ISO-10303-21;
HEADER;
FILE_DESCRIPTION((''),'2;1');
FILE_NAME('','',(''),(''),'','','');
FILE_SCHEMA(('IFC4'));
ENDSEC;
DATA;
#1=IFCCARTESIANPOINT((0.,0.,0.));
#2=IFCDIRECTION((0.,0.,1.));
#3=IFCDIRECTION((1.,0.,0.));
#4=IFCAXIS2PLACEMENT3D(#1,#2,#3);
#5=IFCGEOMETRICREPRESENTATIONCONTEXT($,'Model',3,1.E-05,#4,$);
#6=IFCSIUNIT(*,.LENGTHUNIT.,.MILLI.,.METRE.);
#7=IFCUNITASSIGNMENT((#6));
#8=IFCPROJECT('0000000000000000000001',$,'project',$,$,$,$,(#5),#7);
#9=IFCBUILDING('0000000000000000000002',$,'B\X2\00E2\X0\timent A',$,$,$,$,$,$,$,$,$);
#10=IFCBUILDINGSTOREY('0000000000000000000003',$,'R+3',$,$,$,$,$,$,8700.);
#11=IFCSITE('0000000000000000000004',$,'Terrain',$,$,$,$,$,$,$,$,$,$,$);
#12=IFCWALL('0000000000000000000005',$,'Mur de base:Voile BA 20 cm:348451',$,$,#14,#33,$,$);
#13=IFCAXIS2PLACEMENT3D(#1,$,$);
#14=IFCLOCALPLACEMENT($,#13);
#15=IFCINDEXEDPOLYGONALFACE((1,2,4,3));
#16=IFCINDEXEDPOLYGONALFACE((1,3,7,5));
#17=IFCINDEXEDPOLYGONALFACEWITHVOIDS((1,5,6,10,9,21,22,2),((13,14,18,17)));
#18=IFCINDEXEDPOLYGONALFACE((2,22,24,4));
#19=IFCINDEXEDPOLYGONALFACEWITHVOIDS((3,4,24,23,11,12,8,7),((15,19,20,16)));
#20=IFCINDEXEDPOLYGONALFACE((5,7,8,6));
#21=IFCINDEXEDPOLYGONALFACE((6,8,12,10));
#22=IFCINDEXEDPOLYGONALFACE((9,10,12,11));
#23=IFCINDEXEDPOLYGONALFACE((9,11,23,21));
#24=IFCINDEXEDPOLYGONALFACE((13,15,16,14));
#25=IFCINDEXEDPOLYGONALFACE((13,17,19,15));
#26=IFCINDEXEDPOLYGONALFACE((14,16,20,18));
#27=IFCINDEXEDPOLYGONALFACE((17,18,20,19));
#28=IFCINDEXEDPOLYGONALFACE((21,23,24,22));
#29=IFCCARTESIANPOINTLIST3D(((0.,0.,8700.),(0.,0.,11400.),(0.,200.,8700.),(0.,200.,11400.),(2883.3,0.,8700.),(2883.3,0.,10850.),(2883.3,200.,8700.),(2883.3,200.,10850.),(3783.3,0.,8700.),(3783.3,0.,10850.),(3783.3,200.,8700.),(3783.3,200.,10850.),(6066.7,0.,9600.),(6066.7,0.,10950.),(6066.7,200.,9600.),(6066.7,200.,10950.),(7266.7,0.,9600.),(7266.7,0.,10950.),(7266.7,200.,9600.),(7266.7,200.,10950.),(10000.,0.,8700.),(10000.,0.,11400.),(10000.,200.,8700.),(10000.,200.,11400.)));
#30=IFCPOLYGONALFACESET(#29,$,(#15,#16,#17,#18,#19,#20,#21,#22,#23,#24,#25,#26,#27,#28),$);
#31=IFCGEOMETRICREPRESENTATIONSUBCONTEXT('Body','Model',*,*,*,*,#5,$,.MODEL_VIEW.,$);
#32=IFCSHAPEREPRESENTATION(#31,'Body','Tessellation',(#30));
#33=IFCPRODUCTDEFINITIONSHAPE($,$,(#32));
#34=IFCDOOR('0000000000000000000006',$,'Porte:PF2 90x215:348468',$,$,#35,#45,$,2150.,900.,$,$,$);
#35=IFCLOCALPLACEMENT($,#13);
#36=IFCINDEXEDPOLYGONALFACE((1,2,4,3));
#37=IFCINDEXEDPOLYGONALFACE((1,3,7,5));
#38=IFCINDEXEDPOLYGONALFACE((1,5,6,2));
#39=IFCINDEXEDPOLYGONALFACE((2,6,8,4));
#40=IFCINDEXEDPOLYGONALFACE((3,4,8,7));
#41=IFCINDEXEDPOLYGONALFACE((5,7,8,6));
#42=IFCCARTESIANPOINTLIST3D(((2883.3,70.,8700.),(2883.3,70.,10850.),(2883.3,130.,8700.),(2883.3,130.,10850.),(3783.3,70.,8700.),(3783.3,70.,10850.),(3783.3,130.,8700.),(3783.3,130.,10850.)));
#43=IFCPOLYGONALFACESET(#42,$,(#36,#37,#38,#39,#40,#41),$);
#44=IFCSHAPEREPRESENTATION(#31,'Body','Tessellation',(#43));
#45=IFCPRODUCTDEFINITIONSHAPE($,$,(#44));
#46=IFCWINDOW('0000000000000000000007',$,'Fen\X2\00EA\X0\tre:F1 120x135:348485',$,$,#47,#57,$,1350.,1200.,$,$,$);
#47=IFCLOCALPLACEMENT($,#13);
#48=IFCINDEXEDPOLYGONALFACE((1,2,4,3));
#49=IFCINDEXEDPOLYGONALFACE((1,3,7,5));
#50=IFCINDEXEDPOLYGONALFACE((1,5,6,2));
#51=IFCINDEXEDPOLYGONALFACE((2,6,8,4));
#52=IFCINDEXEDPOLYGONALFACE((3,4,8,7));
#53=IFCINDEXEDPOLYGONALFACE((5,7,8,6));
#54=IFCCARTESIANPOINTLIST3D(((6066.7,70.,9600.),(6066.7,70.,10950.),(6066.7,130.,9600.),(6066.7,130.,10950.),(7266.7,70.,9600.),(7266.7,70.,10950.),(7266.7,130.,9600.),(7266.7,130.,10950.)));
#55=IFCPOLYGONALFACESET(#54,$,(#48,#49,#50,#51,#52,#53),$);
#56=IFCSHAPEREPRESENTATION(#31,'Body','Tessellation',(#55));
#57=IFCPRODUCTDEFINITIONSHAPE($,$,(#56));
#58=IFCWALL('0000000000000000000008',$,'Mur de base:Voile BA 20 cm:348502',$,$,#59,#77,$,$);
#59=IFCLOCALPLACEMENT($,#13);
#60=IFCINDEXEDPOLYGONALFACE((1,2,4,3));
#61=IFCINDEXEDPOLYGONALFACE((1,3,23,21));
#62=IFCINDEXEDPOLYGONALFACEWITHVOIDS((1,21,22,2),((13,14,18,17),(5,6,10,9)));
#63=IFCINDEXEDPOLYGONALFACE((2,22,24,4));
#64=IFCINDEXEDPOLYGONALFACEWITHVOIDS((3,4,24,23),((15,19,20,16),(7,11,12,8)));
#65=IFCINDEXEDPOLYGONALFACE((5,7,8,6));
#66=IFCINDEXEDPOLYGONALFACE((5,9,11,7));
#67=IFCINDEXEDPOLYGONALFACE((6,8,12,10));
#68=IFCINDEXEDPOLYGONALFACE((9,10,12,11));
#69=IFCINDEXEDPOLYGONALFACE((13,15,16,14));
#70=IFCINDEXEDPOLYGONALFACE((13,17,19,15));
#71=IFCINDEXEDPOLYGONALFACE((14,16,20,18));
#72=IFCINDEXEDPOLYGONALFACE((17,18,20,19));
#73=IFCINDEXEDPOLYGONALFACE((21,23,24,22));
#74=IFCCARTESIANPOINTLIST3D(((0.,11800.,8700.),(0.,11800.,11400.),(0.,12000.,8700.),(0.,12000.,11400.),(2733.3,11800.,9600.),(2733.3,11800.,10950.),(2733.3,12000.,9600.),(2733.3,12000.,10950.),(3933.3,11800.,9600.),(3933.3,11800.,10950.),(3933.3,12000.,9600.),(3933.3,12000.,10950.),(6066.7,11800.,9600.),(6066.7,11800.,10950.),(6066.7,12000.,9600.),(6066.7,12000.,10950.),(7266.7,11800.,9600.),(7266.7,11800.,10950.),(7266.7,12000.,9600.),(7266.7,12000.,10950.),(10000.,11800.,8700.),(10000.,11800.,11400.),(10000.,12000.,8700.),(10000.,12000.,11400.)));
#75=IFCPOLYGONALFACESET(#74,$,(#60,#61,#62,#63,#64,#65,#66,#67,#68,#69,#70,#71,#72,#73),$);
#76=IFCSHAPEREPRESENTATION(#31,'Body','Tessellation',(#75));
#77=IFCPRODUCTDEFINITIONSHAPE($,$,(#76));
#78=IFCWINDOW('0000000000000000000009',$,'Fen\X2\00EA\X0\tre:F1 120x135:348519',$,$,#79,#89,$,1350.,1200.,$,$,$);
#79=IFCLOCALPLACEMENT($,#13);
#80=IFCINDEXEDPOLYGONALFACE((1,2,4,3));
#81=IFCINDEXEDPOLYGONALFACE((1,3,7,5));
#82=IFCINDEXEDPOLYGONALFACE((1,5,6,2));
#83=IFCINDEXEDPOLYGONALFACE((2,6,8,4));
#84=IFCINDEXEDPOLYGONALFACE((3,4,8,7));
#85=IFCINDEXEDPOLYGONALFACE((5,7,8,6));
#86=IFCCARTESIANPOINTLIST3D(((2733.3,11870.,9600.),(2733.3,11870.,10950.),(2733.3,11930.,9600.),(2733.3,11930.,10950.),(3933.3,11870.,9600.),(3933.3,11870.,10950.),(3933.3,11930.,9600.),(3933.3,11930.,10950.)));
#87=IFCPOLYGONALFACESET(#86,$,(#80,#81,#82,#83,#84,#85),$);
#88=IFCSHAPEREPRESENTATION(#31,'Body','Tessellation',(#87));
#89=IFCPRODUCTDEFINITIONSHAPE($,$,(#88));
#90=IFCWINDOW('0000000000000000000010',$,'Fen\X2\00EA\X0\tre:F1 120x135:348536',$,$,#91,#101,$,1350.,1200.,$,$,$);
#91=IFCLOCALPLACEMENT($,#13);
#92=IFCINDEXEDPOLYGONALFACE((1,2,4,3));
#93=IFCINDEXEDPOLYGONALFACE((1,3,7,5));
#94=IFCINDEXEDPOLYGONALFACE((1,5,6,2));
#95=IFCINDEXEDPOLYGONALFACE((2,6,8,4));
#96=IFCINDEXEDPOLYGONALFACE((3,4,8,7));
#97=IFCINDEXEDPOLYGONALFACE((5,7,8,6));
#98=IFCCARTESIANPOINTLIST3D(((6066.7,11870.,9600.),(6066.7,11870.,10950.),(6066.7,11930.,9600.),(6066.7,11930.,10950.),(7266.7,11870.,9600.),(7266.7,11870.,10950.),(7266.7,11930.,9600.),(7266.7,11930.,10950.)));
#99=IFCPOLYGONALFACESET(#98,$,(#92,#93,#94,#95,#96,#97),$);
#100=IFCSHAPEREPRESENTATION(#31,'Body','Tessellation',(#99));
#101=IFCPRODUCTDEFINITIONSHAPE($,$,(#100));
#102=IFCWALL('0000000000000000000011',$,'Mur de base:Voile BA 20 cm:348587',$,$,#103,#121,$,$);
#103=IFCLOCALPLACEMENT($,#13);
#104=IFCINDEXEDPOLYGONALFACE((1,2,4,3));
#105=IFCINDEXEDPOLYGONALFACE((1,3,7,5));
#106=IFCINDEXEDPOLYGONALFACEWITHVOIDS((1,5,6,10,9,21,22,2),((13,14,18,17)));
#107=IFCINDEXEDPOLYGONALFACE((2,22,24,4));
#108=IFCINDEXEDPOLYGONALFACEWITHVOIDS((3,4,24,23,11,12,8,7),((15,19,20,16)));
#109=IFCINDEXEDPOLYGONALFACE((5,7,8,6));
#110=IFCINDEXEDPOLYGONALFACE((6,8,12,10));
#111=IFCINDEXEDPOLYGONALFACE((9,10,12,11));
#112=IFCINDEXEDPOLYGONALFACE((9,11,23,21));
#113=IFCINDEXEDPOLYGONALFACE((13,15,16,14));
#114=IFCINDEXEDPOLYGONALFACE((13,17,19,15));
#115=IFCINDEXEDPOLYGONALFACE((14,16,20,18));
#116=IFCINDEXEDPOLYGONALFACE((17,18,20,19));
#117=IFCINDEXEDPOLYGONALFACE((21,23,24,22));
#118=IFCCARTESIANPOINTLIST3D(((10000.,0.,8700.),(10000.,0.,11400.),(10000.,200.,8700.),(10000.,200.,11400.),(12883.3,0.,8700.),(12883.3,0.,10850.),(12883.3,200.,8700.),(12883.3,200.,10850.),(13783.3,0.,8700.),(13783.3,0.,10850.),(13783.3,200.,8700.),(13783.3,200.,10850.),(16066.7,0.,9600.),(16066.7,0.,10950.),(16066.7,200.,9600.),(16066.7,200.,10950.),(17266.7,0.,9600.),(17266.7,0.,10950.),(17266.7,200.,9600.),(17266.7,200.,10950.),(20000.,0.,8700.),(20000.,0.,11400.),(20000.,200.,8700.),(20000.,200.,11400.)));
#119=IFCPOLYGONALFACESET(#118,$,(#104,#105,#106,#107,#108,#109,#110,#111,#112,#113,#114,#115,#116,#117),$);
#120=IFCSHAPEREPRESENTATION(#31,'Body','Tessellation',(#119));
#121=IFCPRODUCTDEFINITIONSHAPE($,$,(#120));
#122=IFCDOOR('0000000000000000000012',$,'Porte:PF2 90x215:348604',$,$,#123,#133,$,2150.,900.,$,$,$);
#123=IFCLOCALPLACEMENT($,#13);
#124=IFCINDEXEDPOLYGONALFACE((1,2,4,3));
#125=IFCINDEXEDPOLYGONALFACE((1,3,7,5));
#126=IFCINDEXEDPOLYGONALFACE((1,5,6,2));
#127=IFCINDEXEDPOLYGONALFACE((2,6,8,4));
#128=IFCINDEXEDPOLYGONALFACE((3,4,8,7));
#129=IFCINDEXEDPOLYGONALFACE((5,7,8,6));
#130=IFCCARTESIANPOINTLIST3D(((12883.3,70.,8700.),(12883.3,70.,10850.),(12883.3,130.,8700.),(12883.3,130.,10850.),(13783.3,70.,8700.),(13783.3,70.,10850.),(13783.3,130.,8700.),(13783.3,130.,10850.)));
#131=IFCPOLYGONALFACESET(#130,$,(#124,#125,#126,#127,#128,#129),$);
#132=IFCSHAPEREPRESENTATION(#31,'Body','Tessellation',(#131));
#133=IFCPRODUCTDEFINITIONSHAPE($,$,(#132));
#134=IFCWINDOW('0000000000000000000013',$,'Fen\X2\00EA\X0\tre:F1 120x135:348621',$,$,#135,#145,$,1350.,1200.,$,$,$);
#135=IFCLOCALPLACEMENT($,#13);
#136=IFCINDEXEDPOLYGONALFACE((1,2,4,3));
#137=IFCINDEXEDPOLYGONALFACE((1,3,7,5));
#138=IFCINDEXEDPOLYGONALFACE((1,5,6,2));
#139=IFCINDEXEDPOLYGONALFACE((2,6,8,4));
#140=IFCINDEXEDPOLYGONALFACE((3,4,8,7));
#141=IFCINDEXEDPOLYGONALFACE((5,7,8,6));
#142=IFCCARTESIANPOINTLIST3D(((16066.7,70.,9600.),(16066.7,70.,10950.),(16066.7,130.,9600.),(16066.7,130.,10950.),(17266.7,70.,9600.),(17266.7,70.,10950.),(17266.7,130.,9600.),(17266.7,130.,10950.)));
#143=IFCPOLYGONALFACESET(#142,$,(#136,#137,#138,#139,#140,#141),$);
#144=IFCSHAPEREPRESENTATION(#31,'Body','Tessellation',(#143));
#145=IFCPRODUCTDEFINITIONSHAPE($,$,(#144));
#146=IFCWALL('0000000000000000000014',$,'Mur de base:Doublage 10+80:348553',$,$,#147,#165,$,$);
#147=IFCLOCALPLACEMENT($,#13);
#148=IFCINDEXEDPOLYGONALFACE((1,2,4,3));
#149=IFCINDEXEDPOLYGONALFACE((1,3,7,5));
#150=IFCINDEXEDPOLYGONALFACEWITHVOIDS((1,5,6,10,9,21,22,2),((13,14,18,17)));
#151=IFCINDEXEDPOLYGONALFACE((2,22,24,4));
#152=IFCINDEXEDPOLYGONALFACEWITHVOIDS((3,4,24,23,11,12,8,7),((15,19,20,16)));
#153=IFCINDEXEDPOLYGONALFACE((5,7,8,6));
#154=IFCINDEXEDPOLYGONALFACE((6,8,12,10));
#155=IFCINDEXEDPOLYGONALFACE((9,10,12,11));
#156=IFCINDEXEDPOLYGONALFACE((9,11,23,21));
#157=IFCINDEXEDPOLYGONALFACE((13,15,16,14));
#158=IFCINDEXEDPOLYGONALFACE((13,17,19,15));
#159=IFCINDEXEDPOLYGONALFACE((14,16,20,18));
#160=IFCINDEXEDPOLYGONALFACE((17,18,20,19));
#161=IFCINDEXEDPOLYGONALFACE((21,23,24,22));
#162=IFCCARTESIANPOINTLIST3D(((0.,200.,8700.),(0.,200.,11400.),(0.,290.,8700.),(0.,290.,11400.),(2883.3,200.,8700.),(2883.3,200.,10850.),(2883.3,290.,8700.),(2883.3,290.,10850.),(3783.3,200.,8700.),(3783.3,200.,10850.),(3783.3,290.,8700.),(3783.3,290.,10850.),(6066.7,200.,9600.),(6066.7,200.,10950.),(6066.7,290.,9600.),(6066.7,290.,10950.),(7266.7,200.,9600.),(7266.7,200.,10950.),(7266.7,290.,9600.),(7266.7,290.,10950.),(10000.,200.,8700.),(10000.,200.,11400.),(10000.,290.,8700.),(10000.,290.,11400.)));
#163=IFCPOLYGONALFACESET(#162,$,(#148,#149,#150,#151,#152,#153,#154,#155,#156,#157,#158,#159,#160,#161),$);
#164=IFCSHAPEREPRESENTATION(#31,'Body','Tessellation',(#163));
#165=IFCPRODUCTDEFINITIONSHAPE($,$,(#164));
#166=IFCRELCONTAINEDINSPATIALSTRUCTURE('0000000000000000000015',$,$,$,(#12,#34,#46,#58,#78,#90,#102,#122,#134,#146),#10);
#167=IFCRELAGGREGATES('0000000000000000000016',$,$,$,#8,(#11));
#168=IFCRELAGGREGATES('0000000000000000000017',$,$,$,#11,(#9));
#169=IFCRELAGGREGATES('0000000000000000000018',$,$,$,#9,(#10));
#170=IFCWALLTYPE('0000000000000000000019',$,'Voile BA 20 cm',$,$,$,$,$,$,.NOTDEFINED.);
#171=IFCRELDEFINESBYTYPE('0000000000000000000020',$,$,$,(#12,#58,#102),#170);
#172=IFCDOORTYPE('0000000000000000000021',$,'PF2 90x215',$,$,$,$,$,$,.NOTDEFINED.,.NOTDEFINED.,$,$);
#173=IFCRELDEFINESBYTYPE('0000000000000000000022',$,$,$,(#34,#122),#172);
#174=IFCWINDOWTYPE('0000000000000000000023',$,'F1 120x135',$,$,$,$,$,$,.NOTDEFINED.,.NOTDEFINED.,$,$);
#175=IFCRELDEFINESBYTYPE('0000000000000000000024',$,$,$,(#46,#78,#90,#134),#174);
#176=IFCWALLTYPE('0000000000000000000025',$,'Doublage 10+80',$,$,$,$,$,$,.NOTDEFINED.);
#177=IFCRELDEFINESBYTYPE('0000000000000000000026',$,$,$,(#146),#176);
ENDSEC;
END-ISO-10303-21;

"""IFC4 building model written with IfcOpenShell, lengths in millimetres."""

from ifc_helpers import new_model, si_unit, frame, frame_2d, origin_with_axes, place, context, subcontext, project, spatial, rectangle, extrude, type_object, element, fill, save


model = new_model("IFC4")

# Units and contexts
model_context = context("Model", 3, precision=1e-05, world=origin_with_axes())
body_context = subcontext(model_context, "Body", "Model", "MODEL_VIEW")
ifc_project = project(units=[si_unit("LENGTHUNIT", "METRE", prefix="MILLI")], contexts=[model_context])

# Site, building, storey
site = spatial("IfcSite", under=ifc_project, Name="Terrain")
building = spatial("IfcBuilding", under=site, Name="Bâtiment A")
storey = spatial("IfcBuildingStorey", under=building, Name="R+3", Elevation=8700.0)

# Wall, openings, door, window
wall_type_1 = type_object("IfcWallType", Name="Voile BA 20 cm", PredefinedType="NOTDEFINED")
wall_1_placement = place(None, origin_with_axes())
wall_1 = element("IfcWall", 1, at=wall_1_placement, inside=storey, type_object=wall_type_1, Name="Mur de base:Voile BA 20 cm:348451", context=body_context, shape_type="SweptSolid", body=[
    extrude(rectangle(XDim=10000.0, YDim=200.0, at=frame_2d((5000.0, 100.0))), frame((0.0, 0.0, 8700.0), z_axis=(0.0, 0.0, 1.0), x_axis=(1.0, 0.0, 0.0)), (0.0, 0.0, 1.0), 2700.0),
])
opening_1_placement = place(None, origin_with_axes())
opening_1 = element("IfcOpeningElement", 2, at=opening_1_placement, cuts=wall_1, context=body_context, shape_type="SweptSolid", body=[
    extrude(rectangle(XDim=900.0, YDim=320.0, at=frame_2d((3333.3, 100.0))), frame((0.0, 0.0, 8700.0), z_axis=(0.0, 0.0, 1.0), x_axis=(1.0, 0.0, 0.0)), (0.0, 0.0, 1.0), 2150.0),
])
opening_2_placement = place(None, origin_with_axes())
opening_2 = element("IfcOpeningElement", 3, at=opening_2_placement, cuts=wall_1, context=body_context, shape_type="SweptSolid", body=[
    extrude(rectangle(XDim=1200.0, YDim=320.0, at=frame_2d((6666.7, 100.0))), frame((0.0, 0.0, 9600.0), z_axis=(0.0, 0.0, 1.0), x_axis=(1.0, 0.0, 0.0)), (0.0, 0.0, 1.0), 1350.0),
])
door_type = type_object("IfcDoorType", Name="PF2 90x215", OperationType="NOTDEFINED", PredefinedType="NOTDEFINED")
door_1_placement = place(None, origin_with_axes())
door_1 = element("IfcDoor", 4, at=door_1_placement, inside=storey, type_object=door_type, Name="Porte:PF2 90x215:348468", OverallHeight=2150.0, OverallWidth=900.0, context=body_context, shape_type="SweptSolid", body=[
    extrude(rectangle(XDim=900.0, YDim=60.0, at=frame_2d((3333.3, 100.0))), frame((0.0, 0.0, 8700.0), z_axis=(0.0, 0.0, 1.0), x_axis=(1.0, 0.0, 0.0)), (0.0, 0.0, 1.0), 2150.0),
])
fill(opening_1, door_1)
window_type = type_object("IfcWindowType", Name="F1 120x135", PartitioningType="NOTDEFINED", PredefinedType="NOTDEFINED")
window_1_placement = place(None, origin_with_axes())
window_1 = element("IfcWindow", 5, at=window_1_placement, inside=storey, type_object=window_type, Name="Fenêtre:F1 120x135:348485", OverallHeight=1350.0, OverallWidth=1200.0, context=body_context, shape_type="SweptSolid", body=[
    extrude(rectangle(XDim=1200.0, YDim=60.0, at=frame_2d((6666.7, 100.0))), frame((0.0, 0.0, 9600.0), z_axis=(0.0, 0.0, 1.0), x_axis=(1.0, 0.0, 0.0)), (0.0, 0.0, 1.0), 1350.0),
])
fill(opening_2, window_1)

# Wall, openings, windows
wall_2_placement = place(None, origin_with_axes())
wall_2 = element("IfcWall", 6, at=wall_2_placement, inside=storey, type_object=wall_type_1, Name="Mur de base:Voile BA 20 cm:348502", context=body_context, shape_type="SweptSolid", body=[
    extrude(rectangle(XDim=10000.0, YDim=200.0, at=frame_2d((5000.0, 11900.0))), frame((0.0, 0.0, 8700.0), z_axis=(0.0, 0.0, 1.0), x_axis=(1.0, 0.0, 0.0)), (0.0, 0.0, 1.0), 2700.0),
])
opening_3_placement = place(None, origin_with_axes())
opening_3 = element("IfcOpeningElement", 7, at=opening_3_placement, cuts=wall_2, context=body_context, shape_type="SweptSolid", body=[
    extrude(rectangle(XDim=1200.0, YDim=320.0, at=frame_2d((3333.3, 11900.0))), frame((0.0, 0.0, 9600.0), z_axis=(0.0, 0.0, 1.0), x_axis=(1.0, 0.0, 0.0)), (0.0, 0.0, 1.0), 1350.0),
])
opening_4_placement = place(None, origin_with_axes())
opening_4 = element("IfcOpeningElement", 8, at=opening_4_placement, cuts=wall_2, context=body_context, shape_type="SweptSolid", body=[
    extrude(rectangle(XDim=1200.0, YDim=320.0, at=frame_2d((6666.7, 11900.0))), frame((0.0, 0.0, 9600.0), z_axis=(0.0, 0.0, 1.0), x_axis=(1.0, 0.0, 0.0)), (0.0, 0.0, 1.0), 1350.0),
])
window_2_placement = place(None, origin_with_axes())
window_2 = element("IfcWindow", 9, at=window_2_placement, inside=storey, type_object=window_type, Name="Fenêtre:F1 120x135:348519", OverallHeight=1350.0, OverallWidth=1200.0, context=body_context, shape_type="SweptSolid", body=[
    extrude(rectangle(XDim=1200.0, YDim=60.0, at=frame_2d((3333.3, 11900.0))), frame((0.0, 0.0, 9600.0), z_axis=(0.0, 0.0, 1.0), x_axis=(1.0, 0.0, 0.0)), (0.0, 0.0, 1.0), 1350.0),
])
fill(opening_3, window_2)
window_3_placement = place(None, origin_with_axes())
window_3 = element("IfcWindow", 10, at=window_3_placement, inside=storey, type_object=window_type, Name="Fenêtre:F1 120x135:348536", OverallHeight=1350.0, OverallWidth=1200.0, context=body_context, shape_type="SweptSolid", body=[
    extrude(rectangle(XDim=1200.0, YDim=60.0, at=frame_2d((6666.7, 11900.0))), frame((0.0, 0.0, 9600.0), z_axis=(0.0, 0.0, 1.0), x_axis=(1.0, 0.0, 0.0)), (0.0, 0.0, 1.0), 1350.0),
])
fill(opening_4, window_3)

# Wall, openings, door, window
wall_3_placement = place(None, origin_with_axes())
wall_3 = element("IfcWall", 11, at=wall_3_placement, inside=storey, type_object=wall_type_1, Name="Mur de base:Voile BA 20 cm:348587", context=body_context, shape_type="SweptSolid", body=[
    extrude(rectangle(XDim=10000.0, YDim=200.0, at=frame_2d((15000.0, 100.0))), frame((0.0, 0.0, 8700.0), z_axis=(0.0, 0.0, 1.0), x_axis=(1.0, 0.0, 0.0)), (0.0, 0.0, 1.0), 2700.0),
])
opening_5_placement = place(None, origin_with_axes())
opening_5 = element("IfcOpeningElement", 12, at=opening_5_placement, cuts=wall_3, context=body_context, shape_type="SweptSolid", body=[
    extrude(rectangle(XDim=900.0, YDim=320.0, at=frame_2d((13333.3, 100.0))), frame((0.0, 0.0, 8700.0), z_axis=(0.0, 0.0, 1.0), x_axis=(1.0, 0.0, 0.0)), (0.0, 0.0, 1.0), 2150.0),
])
opening_6_placement = place(None, origin_with_axes())
opening_6 = element("IfcOpeningElement", 13, at=opening_6_placement, cuts=wall_3, context=body_context, shape_type="SweptSolid", body=[
    extrude(rectangle(XDim=1200.0, YDim=320.0, at=frame_2d((16666.7, 100.0))), frame((0.0, 0.0, 9600.0), z_axis=(0.0, 0.0, 1.0), x_axis=(1.0, 0.0, 0.0)), (0.0, 0.0, 1.0), 1350.0),
])
door_2_placement = place(None, origin_with_axes())
door_2 = element("IfcDoor", 14, at=door_2_placement, inside=storey, type_object=door_type, Name="Porte:PF2 90x215:348604", OverallHeight=2150.0, OverallWidth=900.0, context=body_context, shape_type="SweptSolid", body=[
    extrude(rectangle(XDim=900.0, YDim=60.0, at=frame_2d((13333.3, 100.0))), frame((0.0, 0.0, 8700.0), z_axis=(0.0, 0.0, 1.0), x_axis=(1.0, 0.0, 0.0)), (0.0, 0.0, 1.0), 2150.0),
])
fill(opening_5, door_2)
window_4_placement = place(None, origin_with_axes())
window_4 = element("IfcWindow", 15, at=window_4_placement, inside=storey, type_object=window_type, Name="Fenêtre:F1 120x135:348621", OverallHeight=1350.0, OverallWidth=1200.0, context=body_context, shape_type="SweptSolid", body=[
    extrude(rectangle(XDim=1200.0, YDim=60.0, at=frame_2d((16666.7, 100.0))), frame((0.0, 0.0, 9600.0), z_axis=(0.0, 0.0, 1.0), x_axis=(1.0, 0.0, 0.0)), (0.0, 0.0, 1.0), 1350.0),
])
fill(opening_6, window_4)

# Wall, openings
wall_type_2 = type_object("IfcWallType", Name="Doublage 10+80", PredefinedType="NOTDEFINED")
wall_4_placement = place(None, origin_with_axes())
wall_4 = element("IfcWall", 16, at=wall_4_placement, inside=storey, type_object=wall_type_2, Name="Mur de base:Doublage 10+80:348553", context=body_context, shape_type="SweptSolid", body=[
    extrude(rectangle(XDim=10000.0, YDim=90.0, at=frame_2d((5000.0, 245.0))), frame((0.0, 0.0, 8700.0), z_axis=(0.0, 0.0, 1.0), x_axis=(1.0, 0.0, 0.0)), (0.0, 0.0, 1.0), 2700.0),
])
opening_7_placement = place(None, origin_with_axes())
element("IfcOpeningElement", 17, at=opening_7_placement, cuts=wall_4, context=body_context, shape_type="SweptSolid", body=[
    extrude(rectangle(XDim=900.0, YDim=210.0, at=frame_2d((3333.3, 245.0))), frame((0.0, 0.0, 8700.0), z_axis=(0.0, 0.0, 1.0), x_axis=(1.0, 0.0, 0.0)), (0.0, 0.0, 1.0), 2150.0),
])
opening_8_placement = place(None, origin_with_axes())
element("IfcOpeningElement", 18, at=opening_8_placement, cuts=wall_4, context=body_context, shape_type="SweptSolid", body=[
    extrude(rectangle(XDim=1200.0, YDim=210.0, at=frame_2d((6666.7, 245.0))), frame((0.0, 0.0, 9600.0), z_axis=(0.0, 0.0, 1.0), x_axis=(1.0, 0.0, 0.0)), (0.0, 0.0, 1.0), 1350.0),
])

save(model, "model.ifc")
